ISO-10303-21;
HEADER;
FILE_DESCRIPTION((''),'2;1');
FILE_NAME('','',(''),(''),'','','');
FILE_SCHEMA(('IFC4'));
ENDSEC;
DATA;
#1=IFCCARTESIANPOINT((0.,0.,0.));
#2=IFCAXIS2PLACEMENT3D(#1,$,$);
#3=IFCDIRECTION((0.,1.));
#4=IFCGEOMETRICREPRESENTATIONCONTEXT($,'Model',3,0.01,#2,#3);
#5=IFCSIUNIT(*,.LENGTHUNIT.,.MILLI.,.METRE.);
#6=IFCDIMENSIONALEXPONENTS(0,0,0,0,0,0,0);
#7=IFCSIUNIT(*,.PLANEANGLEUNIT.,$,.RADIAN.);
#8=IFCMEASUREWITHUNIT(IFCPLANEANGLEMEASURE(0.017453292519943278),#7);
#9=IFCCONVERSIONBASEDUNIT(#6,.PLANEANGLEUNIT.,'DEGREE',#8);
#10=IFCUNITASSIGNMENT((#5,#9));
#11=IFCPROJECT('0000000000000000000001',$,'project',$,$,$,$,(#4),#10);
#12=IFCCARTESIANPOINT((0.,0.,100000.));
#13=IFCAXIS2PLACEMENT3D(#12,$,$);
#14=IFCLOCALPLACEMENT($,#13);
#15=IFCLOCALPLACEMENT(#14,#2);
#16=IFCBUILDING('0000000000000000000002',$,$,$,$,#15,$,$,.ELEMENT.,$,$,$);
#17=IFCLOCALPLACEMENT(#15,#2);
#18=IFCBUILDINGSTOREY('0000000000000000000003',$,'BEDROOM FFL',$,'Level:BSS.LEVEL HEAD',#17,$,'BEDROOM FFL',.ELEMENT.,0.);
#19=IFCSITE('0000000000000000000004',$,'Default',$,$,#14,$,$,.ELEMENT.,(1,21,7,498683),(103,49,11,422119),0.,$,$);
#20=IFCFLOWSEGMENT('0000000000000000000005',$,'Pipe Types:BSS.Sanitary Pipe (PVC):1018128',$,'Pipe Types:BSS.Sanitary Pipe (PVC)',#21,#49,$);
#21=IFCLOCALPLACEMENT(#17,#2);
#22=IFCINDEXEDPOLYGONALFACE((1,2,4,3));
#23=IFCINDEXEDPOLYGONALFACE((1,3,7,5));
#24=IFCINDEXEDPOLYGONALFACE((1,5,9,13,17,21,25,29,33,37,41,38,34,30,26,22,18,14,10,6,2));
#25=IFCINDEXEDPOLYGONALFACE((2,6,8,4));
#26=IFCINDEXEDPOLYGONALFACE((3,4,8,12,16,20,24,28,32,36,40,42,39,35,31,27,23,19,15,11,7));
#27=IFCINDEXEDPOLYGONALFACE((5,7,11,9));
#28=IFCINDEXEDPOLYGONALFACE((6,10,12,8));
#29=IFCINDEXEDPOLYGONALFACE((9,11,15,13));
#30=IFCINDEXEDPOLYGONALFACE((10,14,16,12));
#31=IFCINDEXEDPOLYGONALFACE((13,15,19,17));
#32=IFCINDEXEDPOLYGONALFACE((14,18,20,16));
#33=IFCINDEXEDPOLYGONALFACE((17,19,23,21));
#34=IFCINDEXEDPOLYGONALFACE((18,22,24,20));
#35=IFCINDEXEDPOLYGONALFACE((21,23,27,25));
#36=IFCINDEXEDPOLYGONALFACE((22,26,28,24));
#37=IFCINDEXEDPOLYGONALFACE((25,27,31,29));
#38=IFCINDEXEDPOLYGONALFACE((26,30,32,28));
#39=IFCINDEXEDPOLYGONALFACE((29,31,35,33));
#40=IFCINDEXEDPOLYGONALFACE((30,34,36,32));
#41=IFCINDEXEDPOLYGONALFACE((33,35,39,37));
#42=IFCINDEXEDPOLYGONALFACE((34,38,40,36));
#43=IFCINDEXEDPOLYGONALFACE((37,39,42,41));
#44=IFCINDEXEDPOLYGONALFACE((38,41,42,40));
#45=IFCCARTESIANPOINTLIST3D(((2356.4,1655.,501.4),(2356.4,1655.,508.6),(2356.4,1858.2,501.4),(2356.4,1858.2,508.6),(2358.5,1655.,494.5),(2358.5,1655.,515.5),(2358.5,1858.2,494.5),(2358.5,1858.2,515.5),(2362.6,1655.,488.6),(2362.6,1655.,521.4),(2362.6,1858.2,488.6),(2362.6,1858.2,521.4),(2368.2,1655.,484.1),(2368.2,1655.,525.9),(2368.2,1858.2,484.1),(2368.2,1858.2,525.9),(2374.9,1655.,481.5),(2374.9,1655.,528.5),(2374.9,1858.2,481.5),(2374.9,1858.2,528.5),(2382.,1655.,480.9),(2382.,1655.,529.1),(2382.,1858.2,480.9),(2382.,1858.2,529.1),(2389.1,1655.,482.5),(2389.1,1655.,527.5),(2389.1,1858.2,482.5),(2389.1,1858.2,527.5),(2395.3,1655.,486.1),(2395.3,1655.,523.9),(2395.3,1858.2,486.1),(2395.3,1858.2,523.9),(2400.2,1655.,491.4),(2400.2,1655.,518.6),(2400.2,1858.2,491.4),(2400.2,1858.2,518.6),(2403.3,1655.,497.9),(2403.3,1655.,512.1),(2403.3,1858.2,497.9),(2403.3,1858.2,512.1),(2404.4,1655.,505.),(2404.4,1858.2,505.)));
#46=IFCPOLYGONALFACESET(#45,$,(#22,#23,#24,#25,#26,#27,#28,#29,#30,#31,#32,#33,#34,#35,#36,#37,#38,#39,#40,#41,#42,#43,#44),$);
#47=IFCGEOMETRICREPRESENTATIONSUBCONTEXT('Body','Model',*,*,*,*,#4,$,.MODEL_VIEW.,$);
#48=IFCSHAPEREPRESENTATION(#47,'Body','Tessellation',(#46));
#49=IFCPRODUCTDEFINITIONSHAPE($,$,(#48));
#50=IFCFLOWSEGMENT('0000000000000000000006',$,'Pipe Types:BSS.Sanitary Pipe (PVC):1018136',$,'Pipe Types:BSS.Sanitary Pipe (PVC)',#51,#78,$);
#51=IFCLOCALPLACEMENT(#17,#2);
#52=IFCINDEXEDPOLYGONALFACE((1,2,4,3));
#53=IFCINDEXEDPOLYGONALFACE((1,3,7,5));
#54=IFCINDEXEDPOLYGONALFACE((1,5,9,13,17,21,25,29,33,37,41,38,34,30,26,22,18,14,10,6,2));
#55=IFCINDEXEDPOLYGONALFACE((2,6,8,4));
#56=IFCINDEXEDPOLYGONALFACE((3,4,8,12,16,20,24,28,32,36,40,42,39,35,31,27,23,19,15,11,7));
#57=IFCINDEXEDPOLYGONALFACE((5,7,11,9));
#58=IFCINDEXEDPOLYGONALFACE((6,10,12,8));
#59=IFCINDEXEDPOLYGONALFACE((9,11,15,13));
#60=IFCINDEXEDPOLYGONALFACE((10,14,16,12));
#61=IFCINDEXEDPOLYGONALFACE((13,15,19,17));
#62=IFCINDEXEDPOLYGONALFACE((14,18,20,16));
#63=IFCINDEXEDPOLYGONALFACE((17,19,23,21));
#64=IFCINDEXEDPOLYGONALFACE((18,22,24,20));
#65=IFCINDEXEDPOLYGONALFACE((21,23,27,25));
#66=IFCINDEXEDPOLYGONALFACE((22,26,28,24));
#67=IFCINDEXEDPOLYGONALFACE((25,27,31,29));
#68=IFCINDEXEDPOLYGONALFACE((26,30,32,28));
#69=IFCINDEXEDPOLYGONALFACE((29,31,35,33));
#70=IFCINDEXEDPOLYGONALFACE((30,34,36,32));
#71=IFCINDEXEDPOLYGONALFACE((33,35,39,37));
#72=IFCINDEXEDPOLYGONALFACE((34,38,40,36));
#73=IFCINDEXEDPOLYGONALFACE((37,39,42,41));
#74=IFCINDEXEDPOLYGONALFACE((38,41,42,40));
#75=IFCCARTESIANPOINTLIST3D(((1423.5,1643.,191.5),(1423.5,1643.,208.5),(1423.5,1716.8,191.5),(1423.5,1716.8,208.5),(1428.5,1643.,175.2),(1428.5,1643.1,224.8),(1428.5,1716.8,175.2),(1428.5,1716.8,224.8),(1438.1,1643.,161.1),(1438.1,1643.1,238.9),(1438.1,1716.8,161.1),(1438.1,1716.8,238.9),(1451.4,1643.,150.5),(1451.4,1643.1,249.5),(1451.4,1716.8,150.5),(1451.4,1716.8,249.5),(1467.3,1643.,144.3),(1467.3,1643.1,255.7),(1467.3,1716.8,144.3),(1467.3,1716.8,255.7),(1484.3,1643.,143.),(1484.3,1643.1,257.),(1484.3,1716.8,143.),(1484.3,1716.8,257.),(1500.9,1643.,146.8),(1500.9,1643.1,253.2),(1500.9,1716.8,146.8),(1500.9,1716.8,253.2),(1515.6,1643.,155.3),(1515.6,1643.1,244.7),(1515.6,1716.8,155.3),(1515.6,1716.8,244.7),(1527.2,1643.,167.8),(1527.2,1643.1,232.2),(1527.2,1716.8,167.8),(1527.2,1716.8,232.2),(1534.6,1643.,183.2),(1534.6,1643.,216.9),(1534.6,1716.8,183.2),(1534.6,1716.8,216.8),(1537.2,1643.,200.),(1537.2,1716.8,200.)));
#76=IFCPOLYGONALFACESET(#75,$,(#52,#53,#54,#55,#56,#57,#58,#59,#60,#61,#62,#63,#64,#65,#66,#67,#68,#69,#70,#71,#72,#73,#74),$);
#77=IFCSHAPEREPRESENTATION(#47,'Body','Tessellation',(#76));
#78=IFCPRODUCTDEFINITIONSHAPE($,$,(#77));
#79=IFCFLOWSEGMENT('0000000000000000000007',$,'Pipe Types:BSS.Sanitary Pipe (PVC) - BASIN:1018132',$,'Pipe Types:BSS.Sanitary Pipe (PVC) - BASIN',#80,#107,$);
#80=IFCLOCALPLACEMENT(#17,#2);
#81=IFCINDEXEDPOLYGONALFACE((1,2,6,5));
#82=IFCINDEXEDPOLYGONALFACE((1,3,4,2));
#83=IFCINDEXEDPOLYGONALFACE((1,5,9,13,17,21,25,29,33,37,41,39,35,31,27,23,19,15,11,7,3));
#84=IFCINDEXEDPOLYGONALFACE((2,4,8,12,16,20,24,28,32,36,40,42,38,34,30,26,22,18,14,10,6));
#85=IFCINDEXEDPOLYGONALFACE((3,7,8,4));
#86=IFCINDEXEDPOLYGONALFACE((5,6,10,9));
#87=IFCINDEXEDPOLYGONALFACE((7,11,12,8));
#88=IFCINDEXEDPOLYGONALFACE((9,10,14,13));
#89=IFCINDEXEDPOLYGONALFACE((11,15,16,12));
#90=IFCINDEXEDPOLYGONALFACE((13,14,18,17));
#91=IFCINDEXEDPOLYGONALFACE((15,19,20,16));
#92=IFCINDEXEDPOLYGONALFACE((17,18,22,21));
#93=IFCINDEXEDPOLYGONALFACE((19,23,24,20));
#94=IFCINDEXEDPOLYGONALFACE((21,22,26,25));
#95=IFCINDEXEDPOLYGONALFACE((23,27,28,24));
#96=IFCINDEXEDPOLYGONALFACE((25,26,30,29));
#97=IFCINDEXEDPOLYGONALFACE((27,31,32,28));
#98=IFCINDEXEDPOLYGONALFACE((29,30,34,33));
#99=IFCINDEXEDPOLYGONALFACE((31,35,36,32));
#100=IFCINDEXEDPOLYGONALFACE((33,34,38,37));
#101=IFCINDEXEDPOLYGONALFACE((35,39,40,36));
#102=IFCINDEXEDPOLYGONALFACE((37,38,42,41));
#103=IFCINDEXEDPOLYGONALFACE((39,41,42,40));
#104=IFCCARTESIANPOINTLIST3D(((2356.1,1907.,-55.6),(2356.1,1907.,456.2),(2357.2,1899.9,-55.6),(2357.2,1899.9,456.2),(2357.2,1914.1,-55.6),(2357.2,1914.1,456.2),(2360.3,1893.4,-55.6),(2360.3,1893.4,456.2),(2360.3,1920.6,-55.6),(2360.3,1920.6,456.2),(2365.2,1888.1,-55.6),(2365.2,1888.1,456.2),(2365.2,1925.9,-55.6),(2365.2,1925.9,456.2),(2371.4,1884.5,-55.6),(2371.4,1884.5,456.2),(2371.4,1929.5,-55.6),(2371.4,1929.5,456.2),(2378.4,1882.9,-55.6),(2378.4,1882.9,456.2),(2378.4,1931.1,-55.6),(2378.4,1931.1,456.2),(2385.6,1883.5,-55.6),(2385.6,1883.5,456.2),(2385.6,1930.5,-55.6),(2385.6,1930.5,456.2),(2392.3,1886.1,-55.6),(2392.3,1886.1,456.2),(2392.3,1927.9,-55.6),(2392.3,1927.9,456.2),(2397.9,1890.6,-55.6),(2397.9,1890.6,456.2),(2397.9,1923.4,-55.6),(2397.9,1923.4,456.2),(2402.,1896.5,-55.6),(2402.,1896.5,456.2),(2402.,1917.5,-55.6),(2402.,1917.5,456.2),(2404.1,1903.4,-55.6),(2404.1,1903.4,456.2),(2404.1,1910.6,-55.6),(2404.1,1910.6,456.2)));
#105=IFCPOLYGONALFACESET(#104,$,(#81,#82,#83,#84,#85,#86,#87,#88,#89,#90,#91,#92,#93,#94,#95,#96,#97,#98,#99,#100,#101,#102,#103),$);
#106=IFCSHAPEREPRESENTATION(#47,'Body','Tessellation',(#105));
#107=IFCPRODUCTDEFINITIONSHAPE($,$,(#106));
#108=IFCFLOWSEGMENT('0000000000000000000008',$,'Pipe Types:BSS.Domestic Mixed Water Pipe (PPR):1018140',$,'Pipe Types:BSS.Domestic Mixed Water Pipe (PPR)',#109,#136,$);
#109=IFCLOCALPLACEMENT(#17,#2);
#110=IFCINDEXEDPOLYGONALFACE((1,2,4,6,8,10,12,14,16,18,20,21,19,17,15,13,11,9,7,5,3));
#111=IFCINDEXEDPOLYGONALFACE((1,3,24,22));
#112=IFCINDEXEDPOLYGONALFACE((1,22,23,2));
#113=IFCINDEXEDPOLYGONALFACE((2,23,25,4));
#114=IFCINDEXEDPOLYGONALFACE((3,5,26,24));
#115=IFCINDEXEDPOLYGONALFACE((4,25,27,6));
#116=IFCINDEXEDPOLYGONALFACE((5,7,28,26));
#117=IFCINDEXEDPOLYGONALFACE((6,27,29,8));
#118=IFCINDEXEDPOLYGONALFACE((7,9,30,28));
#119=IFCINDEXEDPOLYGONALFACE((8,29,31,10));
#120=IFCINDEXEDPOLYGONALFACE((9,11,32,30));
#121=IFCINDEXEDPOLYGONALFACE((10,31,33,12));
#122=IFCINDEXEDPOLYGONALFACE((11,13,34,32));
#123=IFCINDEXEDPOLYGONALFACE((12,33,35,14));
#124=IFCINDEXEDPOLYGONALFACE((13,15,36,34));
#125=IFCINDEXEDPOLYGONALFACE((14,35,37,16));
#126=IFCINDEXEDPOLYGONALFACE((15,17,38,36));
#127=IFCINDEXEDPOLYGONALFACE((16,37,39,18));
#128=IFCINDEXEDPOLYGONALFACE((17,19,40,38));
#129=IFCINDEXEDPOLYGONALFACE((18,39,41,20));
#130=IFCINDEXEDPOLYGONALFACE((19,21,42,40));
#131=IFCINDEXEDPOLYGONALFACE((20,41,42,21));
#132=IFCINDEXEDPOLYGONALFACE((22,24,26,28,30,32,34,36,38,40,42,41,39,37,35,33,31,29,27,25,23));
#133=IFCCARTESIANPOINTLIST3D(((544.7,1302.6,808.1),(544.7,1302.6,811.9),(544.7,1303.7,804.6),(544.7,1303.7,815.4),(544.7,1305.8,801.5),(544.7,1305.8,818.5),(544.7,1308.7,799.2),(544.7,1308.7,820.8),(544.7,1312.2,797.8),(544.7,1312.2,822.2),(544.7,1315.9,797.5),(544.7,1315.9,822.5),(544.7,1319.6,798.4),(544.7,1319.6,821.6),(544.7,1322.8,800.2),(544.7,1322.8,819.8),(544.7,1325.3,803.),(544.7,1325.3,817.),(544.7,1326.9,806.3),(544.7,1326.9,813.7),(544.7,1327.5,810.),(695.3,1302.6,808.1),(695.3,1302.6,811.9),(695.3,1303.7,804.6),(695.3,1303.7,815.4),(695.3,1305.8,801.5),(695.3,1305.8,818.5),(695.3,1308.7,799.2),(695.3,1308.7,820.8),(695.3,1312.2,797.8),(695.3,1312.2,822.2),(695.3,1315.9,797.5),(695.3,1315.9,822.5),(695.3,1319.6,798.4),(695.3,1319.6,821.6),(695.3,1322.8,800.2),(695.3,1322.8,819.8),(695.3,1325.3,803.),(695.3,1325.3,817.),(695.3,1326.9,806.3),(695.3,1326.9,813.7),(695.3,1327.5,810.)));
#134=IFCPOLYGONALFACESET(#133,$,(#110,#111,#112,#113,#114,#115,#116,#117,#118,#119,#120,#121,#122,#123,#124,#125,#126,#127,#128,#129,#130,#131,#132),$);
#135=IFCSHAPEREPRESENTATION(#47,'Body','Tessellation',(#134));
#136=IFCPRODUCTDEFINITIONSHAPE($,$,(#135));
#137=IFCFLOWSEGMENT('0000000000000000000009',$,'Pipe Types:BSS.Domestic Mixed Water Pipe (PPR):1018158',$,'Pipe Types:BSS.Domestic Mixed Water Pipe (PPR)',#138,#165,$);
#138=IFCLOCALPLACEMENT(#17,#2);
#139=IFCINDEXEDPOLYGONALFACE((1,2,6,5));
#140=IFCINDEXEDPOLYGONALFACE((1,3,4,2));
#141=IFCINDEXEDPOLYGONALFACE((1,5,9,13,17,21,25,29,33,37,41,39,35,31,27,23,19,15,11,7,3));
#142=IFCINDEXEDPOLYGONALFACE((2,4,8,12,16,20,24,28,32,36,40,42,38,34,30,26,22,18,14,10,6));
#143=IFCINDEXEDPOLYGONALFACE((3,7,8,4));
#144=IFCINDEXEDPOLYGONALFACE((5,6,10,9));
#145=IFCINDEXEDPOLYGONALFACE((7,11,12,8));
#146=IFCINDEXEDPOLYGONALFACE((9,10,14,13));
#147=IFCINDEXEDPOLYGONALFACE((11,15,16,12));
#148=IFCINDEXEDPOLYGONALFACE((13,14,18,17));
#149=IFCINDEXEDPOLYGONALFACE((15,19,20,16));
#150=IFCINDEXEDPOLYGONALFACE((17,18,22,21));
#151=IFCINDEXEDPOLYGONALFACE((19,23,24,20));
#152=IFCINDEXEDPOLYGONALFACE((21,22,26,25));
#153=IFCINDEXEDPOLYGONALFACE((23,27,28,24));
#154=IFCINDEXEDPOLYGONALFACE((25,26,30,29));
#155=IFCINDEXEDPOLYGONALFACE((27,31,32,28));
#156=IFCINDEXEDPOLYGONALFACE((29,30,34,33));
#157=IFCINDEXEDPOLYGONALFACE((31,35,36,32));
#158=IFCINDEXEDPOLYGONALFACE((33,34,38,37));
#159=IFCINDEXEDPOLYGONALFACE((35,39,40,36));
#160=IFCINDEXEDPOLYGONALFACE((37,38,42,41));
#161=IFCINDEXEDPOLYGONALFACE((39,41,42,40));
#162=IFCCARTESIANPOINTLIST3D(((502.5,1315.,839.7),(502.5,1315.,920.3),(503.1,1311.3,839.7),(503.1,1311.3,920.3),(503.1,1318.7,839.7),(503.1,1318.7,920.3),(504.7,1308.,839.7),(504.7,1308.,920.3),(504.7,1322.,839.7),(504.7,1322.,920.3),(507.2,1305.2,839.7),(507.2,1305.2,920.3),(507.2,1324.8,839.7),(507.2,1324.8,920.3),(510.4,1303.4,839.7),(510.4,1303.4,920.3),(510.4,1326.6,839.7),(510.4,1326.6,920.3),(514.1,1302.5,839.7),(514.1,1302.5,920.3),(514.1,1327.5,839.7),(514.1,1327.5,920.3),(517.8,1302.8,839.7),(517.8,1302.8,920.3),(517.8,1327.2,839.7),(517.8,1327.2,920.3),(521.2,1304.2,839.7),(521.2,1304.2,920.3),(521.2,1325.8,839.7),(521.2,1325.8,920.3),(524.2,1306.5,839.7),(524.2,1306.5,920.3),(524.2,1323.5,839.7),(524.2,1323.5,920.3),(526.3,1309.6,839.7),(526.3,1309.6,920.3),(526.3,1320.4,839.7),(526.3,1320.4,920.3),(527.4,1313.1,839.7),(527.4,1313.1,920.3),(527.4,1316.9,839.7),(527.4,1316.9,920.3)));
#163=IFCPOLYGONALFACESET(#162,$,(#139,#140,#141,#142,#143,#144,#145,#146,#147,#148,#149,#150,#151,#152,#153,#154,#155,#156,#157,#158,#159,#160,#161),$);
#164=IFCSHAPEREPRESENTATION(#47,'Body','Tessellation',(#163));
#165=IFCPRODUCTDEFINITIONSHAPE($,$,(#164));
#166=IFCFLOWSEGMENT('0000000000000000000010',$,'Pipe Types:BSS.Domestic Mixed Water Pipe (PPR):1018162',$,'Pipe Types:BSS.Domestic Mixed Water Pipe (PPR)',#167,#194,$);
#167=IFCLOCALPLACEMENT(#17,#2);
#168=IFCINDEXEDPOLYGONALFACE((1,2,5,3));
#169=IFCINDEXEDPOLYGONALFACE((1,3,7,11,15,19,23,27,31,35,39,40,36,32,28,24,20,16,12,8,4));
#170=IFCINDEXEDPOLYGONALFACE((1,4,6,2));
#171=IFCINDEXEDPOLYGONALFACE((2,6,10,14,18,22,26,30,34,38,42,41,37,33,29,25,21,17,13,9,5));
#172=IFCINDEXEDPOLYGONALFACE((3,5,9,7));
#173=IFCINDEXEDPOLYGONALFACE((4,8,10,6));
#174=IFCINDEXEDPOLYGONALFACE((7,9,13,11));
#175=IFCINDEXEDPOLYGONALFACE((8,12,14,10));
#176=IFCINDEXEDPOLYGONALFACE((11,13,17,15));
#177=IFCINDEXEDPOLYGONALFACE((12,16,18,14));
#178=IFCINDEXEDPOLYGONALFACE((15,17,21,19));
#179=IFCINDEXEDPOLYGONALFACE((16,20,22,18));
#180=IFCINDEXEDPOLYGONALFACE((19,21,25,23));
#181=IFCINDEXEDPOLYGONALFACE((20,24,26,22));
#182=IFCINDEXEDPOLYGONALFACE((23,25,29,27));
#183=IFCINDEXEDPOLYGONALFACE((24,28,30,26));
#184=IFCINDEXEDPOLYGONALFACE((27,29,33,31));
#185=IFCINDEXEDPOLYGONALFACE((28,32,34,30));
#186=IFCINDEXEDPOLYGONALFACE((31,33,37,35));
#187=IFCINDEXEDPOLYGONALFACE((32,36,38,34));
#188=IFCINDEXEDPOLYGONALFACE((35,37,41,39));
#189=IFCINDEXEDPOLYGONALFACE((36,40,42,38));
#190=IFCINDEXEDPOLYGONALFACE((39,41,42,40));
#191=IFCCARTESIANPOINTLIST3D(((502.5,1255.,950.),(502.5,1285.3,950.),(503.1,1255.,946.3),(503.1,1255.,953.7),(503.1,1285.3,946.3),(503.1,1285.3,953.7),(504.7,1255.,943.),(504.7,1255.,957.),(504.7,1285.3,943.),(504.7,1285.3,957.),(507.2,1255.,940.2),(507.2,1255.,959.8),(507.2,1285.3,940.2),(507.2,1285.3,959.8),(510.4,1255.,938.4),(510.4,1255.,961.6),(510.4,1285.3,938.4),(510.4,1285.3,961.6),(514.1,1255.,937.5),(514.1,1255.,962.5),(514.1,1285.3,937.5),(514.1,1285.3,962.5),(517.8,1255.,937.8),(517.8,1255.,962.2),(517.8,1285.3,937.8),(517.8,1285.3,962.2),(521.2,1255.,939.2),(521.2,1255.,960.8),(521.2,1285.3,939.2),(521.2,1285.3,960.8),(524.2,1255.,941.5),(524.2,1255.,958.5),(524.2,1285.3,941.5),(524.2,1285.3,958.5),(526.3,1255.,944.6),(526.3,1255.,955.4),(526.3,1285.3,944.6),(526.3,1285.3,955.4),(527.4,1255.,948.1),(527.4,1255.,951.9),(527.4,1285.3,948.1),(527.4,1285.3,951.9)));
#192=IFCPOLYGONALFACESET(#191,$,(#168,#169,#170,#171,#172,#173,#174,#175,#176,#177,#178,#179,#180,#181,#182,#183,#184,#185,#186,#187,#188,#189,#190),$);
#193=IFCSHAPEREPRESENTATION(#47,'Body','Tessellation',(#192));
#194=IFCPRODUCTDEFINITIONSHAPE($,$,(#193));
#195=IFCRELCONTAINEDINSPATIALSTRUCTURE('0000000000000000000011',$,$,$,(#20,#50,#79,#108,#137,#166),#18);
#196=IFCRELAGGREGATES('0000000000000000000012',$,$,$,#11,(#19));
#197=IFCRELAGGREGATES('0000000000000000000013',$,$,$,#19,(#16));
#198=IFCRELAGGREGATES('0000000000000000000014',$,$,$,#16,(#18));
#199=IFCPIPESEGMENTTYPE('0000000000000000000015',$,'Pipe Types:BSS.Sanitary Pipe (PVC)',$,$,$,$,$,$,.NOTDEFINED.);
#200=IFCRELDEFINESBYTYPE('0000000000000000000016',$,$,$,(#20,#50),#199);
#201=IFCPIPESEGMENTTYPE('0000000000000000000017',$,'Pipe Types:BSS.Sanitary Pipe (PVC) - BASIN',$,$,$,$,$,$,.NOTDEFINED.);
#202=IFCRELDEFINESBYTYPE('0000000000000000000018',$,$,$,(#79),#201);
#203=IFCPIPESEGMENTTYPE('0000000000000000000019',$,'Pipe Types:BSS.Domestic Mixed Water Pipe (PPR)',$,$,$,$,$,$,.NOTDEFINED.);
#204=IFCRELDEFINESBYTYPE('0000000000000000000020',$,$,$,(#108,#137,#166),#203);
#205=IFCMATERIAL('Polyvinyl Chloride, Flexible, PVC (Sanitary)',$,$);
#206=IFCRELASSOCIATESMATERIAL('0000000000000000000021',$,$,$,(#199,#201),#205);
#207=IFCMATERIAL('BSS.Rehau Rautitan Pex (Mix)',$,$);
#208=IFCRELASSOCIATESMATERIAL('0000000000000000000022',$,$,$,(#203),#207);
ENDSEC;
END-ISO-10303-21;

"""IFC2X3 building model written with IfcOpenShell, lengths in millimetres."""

from ifc_helpers import new_model, entity, si_unit, converted_unit, direction, frame, frame_2d, origin, origin_2d_with_axis, place, context, subcontext, project, spatial, circle, extrude, material, type_object, element, save


model = new_model("IFC2X3")

# Units and contexts
model_context = context("Model", 3, precision=0.01, world=origin(), true_north=direction((0.0, 1.0)))
body_context = subcontext(model_context, "Body", "Model", "MODEL_VIEW")
ifc_project = project(units=[si_unit("LENGTHUNIT", "METRE", prefix="MILLI"), converted_unit("PLANEANGLEUNIT", "DEGREE", entity("IfcPlaneAngleMeasure", 0.017453292519943278), si_unit("PLANEANGLEUNIT", "RADIAN"), dimensions=[0, 0, 0, 0, 0, 0, 0])], contexts=[model_context])

# Site, building, storey
site_placement = place(None, frame((0.0, 0.0, 100000.0)))
site = spatial("IfcSite", under=ifc_project, at=site_placement, Name="Default", CompositionType="ELEMENT", RefLatitude=(1, 21, 7, 498683), RefLongitude=(103, 49, 11, 422119), RefElevation=0.0)
building_placement = place(site_placement, origin())
building = spatial("IfcBuilding", under=site, at=building_placement, CompositionType="ELEMENT")
storey_placement = place(building_placement, origin())
storey = spatial("IfcBuildingStorey", under=building, at=storey_placement, Name="BEDROOM FFL", ObjectType="Level:BSS.LEVEL HEAD", LongName="BEDROOM FFL", CompositionType="ELEMENT", Elevation=0.0)

# Flow segments
ifc_material_1 = material(Name="Polyvinyl Chloride, Flexible, PVC (Sanitary)")
pipe_segment_type_1 = type_object("IfcPipeSegmentType", Name="Pipe Types:BSS.Sanitary Pipe (PVC)", PredefinedType="NOTDEFINED", material=ifc_material_1)
flow_segment_1_placement = place(storey_placement, origin())
element("IfcFlowSegment", 1, at=flow_segment_1_placement, inside=storey, type_object=pipe_segment_type_1, Name="Pipe Types:BSS.Sanitary Pipe (PVC):1018128", ObjectType="Pipe Types:BSS.Sanitary Pipe (PVC)", context=body_context, shape_type="SweptSolid", body=[
    extrude(circle(Radius=24.1, at=origin_2d_with_axis()), frame((2380.2, 1655.0, 505.0), z_axis=(0.0, 1.0, 0.0), x_axis=(1.0, 0.0, 0.0)), (0.0, 0.0, 1.0), 203.2),
])
flow_segment_2_placement = place(storey_placement, origin())
element("IfcFlowSegment", 2, at=flow_segment_2_placement, inside=storey, type_object=pipe_segment_type_1, Name="Pipe Types:BSS.Sanitary Pipe (PVC):1018136", ObjectType="Pipe Types:BSS.Sanitary Pipe (PVC)", context=body_context, shape_type="SweptSolid", body=[
    extrude(circle(Radius=57.2, at=frame_2d((0.0, 0.0), x_axis=(1.0, 0.0))), frame((1480.0, 1716.8, 200.0), z_axis=(0.0, -1.0, 0.000211), x_axis=(1.0, 0.0, 0.0)), (0.0, 0.0, 1.0), 73.8),
])
pipe_segment_type_2 = type_object("IfcPipeSegmentType", Name="Pipe Types:BSS.Sanitary Pipe (PVC) - BASIN", PredefinedType="NOTDEFINED", material=ifc_material_1)
flow_segment_3_placement = place(storey_placement, origin())
element("IfcFlowSegment", 3, at=flow_segment_3_placement, inside=storey, type_object=pipe_segment_type_2, Name="Pipe Types:BSS.Sanitary Pipe (PVC) - BASIN:1018132", ObjectType="Pipe Types:BSS.Sanitary Pipe (PVC) - BASIN", context=body_context, shape_type="SweptSolid", body=[
    extrude(circle(Radius=24.1, at=frame_2d((0.0, 0.0), x_axis=(1.0, 0.0))), frame((2380.2, 1907.0, -55.6), z_axis=(0.0, 0.0, 1.0), x_axis=(-1.0, 0.0, 0.0)), (0.0, 0.0, 1.0), 511.8),
])
ifc_material_2 = material(Name="BSS.Rehau Rautitan Pex (Mix)")
pipe_segment_type_3 = type_object("IfcPipeSegmentType", Name="Pipe Types:BSS.Domestic Mixed Water Pipe (PPR)", PredefinedType="NOTDEFINED", material=ifc_material_2)
flow_segment_4_placement = place(storey_placement, origin())
element("IfcFlowSegment", 4, at=flow_segment_4_placement, inside=storey, type_object=pipe_segment_type_3, Name="Pipe Types:BSS.Domestic Mixed Water Pipe (PPR):1018140", ObjectType="Pipe Types:BSS.Domestic Mixed Water Pipe (PPR)", context=body_context, shape_type="SweptSolid", body=[
    extrude(circle(Radius=12.5, at=frame_2d((0.0, 0.0), x_axis=(1.0, 0.0))), frame((544.7, 1315.0, 810.0), z_axis=(1.0, 0.0, 0.0), x_axis=(0.0, 1.0, 0.0)), (0.0, 0.0, 1.0), 150.6),
])
flow_segment_5_placement = place(storey_placement, origin())
element("IfcFlowSegment", 5, at=flow_segment_5_placement, inside=storey, type_object=pipe_segment_type_3, Name="Pipe Types:BSS.Domestic Mixed Water Pipe (PPR):1018158", ObjectType="Pipe Types:BSS.Domestic Mixed Water Pipe (PPR)", context=body_context, shape_type="SweptSolid", body=[
    extrude(circle(Radius=12.5, at=origin_2d_with_axis()), frame((515.0, 1315.0, 839.7), z_axis=(0.0, 0.0, 1.0), x_axis=(-1.0, 0.0, 0.0)), (0.0, 0.0, 1.0), 80.6),
])
flow_segment_6_placement = place(storey_placement, origin())
element("IfcFlowSegment", 6, at=flow_segment_6_placement, inside=storey, type_object=pipe_segment_type_3, Name="Pipe Types:BSS.Domestic Mixed Water Pipe (PPR):1018162", ObjectType="Pipe Types:BSS.Domestic Mixed Water Pipe (PPR)", context=body_context, shape_type="SweptSolid", body=[
    extrude(circle(Radius=12.5, at=frame_2d((0.0, 0.0), x_axis=(1.0, 0.0))), frame((515.0, 1255.0, 950.0), z_axis=(0.0, 1.0, 0.0), x_axis=(-1.0, 0.0, 0.0)), (0.0, 0.0, 1.0), 30.3),
])

save(model, "model.ifc")
